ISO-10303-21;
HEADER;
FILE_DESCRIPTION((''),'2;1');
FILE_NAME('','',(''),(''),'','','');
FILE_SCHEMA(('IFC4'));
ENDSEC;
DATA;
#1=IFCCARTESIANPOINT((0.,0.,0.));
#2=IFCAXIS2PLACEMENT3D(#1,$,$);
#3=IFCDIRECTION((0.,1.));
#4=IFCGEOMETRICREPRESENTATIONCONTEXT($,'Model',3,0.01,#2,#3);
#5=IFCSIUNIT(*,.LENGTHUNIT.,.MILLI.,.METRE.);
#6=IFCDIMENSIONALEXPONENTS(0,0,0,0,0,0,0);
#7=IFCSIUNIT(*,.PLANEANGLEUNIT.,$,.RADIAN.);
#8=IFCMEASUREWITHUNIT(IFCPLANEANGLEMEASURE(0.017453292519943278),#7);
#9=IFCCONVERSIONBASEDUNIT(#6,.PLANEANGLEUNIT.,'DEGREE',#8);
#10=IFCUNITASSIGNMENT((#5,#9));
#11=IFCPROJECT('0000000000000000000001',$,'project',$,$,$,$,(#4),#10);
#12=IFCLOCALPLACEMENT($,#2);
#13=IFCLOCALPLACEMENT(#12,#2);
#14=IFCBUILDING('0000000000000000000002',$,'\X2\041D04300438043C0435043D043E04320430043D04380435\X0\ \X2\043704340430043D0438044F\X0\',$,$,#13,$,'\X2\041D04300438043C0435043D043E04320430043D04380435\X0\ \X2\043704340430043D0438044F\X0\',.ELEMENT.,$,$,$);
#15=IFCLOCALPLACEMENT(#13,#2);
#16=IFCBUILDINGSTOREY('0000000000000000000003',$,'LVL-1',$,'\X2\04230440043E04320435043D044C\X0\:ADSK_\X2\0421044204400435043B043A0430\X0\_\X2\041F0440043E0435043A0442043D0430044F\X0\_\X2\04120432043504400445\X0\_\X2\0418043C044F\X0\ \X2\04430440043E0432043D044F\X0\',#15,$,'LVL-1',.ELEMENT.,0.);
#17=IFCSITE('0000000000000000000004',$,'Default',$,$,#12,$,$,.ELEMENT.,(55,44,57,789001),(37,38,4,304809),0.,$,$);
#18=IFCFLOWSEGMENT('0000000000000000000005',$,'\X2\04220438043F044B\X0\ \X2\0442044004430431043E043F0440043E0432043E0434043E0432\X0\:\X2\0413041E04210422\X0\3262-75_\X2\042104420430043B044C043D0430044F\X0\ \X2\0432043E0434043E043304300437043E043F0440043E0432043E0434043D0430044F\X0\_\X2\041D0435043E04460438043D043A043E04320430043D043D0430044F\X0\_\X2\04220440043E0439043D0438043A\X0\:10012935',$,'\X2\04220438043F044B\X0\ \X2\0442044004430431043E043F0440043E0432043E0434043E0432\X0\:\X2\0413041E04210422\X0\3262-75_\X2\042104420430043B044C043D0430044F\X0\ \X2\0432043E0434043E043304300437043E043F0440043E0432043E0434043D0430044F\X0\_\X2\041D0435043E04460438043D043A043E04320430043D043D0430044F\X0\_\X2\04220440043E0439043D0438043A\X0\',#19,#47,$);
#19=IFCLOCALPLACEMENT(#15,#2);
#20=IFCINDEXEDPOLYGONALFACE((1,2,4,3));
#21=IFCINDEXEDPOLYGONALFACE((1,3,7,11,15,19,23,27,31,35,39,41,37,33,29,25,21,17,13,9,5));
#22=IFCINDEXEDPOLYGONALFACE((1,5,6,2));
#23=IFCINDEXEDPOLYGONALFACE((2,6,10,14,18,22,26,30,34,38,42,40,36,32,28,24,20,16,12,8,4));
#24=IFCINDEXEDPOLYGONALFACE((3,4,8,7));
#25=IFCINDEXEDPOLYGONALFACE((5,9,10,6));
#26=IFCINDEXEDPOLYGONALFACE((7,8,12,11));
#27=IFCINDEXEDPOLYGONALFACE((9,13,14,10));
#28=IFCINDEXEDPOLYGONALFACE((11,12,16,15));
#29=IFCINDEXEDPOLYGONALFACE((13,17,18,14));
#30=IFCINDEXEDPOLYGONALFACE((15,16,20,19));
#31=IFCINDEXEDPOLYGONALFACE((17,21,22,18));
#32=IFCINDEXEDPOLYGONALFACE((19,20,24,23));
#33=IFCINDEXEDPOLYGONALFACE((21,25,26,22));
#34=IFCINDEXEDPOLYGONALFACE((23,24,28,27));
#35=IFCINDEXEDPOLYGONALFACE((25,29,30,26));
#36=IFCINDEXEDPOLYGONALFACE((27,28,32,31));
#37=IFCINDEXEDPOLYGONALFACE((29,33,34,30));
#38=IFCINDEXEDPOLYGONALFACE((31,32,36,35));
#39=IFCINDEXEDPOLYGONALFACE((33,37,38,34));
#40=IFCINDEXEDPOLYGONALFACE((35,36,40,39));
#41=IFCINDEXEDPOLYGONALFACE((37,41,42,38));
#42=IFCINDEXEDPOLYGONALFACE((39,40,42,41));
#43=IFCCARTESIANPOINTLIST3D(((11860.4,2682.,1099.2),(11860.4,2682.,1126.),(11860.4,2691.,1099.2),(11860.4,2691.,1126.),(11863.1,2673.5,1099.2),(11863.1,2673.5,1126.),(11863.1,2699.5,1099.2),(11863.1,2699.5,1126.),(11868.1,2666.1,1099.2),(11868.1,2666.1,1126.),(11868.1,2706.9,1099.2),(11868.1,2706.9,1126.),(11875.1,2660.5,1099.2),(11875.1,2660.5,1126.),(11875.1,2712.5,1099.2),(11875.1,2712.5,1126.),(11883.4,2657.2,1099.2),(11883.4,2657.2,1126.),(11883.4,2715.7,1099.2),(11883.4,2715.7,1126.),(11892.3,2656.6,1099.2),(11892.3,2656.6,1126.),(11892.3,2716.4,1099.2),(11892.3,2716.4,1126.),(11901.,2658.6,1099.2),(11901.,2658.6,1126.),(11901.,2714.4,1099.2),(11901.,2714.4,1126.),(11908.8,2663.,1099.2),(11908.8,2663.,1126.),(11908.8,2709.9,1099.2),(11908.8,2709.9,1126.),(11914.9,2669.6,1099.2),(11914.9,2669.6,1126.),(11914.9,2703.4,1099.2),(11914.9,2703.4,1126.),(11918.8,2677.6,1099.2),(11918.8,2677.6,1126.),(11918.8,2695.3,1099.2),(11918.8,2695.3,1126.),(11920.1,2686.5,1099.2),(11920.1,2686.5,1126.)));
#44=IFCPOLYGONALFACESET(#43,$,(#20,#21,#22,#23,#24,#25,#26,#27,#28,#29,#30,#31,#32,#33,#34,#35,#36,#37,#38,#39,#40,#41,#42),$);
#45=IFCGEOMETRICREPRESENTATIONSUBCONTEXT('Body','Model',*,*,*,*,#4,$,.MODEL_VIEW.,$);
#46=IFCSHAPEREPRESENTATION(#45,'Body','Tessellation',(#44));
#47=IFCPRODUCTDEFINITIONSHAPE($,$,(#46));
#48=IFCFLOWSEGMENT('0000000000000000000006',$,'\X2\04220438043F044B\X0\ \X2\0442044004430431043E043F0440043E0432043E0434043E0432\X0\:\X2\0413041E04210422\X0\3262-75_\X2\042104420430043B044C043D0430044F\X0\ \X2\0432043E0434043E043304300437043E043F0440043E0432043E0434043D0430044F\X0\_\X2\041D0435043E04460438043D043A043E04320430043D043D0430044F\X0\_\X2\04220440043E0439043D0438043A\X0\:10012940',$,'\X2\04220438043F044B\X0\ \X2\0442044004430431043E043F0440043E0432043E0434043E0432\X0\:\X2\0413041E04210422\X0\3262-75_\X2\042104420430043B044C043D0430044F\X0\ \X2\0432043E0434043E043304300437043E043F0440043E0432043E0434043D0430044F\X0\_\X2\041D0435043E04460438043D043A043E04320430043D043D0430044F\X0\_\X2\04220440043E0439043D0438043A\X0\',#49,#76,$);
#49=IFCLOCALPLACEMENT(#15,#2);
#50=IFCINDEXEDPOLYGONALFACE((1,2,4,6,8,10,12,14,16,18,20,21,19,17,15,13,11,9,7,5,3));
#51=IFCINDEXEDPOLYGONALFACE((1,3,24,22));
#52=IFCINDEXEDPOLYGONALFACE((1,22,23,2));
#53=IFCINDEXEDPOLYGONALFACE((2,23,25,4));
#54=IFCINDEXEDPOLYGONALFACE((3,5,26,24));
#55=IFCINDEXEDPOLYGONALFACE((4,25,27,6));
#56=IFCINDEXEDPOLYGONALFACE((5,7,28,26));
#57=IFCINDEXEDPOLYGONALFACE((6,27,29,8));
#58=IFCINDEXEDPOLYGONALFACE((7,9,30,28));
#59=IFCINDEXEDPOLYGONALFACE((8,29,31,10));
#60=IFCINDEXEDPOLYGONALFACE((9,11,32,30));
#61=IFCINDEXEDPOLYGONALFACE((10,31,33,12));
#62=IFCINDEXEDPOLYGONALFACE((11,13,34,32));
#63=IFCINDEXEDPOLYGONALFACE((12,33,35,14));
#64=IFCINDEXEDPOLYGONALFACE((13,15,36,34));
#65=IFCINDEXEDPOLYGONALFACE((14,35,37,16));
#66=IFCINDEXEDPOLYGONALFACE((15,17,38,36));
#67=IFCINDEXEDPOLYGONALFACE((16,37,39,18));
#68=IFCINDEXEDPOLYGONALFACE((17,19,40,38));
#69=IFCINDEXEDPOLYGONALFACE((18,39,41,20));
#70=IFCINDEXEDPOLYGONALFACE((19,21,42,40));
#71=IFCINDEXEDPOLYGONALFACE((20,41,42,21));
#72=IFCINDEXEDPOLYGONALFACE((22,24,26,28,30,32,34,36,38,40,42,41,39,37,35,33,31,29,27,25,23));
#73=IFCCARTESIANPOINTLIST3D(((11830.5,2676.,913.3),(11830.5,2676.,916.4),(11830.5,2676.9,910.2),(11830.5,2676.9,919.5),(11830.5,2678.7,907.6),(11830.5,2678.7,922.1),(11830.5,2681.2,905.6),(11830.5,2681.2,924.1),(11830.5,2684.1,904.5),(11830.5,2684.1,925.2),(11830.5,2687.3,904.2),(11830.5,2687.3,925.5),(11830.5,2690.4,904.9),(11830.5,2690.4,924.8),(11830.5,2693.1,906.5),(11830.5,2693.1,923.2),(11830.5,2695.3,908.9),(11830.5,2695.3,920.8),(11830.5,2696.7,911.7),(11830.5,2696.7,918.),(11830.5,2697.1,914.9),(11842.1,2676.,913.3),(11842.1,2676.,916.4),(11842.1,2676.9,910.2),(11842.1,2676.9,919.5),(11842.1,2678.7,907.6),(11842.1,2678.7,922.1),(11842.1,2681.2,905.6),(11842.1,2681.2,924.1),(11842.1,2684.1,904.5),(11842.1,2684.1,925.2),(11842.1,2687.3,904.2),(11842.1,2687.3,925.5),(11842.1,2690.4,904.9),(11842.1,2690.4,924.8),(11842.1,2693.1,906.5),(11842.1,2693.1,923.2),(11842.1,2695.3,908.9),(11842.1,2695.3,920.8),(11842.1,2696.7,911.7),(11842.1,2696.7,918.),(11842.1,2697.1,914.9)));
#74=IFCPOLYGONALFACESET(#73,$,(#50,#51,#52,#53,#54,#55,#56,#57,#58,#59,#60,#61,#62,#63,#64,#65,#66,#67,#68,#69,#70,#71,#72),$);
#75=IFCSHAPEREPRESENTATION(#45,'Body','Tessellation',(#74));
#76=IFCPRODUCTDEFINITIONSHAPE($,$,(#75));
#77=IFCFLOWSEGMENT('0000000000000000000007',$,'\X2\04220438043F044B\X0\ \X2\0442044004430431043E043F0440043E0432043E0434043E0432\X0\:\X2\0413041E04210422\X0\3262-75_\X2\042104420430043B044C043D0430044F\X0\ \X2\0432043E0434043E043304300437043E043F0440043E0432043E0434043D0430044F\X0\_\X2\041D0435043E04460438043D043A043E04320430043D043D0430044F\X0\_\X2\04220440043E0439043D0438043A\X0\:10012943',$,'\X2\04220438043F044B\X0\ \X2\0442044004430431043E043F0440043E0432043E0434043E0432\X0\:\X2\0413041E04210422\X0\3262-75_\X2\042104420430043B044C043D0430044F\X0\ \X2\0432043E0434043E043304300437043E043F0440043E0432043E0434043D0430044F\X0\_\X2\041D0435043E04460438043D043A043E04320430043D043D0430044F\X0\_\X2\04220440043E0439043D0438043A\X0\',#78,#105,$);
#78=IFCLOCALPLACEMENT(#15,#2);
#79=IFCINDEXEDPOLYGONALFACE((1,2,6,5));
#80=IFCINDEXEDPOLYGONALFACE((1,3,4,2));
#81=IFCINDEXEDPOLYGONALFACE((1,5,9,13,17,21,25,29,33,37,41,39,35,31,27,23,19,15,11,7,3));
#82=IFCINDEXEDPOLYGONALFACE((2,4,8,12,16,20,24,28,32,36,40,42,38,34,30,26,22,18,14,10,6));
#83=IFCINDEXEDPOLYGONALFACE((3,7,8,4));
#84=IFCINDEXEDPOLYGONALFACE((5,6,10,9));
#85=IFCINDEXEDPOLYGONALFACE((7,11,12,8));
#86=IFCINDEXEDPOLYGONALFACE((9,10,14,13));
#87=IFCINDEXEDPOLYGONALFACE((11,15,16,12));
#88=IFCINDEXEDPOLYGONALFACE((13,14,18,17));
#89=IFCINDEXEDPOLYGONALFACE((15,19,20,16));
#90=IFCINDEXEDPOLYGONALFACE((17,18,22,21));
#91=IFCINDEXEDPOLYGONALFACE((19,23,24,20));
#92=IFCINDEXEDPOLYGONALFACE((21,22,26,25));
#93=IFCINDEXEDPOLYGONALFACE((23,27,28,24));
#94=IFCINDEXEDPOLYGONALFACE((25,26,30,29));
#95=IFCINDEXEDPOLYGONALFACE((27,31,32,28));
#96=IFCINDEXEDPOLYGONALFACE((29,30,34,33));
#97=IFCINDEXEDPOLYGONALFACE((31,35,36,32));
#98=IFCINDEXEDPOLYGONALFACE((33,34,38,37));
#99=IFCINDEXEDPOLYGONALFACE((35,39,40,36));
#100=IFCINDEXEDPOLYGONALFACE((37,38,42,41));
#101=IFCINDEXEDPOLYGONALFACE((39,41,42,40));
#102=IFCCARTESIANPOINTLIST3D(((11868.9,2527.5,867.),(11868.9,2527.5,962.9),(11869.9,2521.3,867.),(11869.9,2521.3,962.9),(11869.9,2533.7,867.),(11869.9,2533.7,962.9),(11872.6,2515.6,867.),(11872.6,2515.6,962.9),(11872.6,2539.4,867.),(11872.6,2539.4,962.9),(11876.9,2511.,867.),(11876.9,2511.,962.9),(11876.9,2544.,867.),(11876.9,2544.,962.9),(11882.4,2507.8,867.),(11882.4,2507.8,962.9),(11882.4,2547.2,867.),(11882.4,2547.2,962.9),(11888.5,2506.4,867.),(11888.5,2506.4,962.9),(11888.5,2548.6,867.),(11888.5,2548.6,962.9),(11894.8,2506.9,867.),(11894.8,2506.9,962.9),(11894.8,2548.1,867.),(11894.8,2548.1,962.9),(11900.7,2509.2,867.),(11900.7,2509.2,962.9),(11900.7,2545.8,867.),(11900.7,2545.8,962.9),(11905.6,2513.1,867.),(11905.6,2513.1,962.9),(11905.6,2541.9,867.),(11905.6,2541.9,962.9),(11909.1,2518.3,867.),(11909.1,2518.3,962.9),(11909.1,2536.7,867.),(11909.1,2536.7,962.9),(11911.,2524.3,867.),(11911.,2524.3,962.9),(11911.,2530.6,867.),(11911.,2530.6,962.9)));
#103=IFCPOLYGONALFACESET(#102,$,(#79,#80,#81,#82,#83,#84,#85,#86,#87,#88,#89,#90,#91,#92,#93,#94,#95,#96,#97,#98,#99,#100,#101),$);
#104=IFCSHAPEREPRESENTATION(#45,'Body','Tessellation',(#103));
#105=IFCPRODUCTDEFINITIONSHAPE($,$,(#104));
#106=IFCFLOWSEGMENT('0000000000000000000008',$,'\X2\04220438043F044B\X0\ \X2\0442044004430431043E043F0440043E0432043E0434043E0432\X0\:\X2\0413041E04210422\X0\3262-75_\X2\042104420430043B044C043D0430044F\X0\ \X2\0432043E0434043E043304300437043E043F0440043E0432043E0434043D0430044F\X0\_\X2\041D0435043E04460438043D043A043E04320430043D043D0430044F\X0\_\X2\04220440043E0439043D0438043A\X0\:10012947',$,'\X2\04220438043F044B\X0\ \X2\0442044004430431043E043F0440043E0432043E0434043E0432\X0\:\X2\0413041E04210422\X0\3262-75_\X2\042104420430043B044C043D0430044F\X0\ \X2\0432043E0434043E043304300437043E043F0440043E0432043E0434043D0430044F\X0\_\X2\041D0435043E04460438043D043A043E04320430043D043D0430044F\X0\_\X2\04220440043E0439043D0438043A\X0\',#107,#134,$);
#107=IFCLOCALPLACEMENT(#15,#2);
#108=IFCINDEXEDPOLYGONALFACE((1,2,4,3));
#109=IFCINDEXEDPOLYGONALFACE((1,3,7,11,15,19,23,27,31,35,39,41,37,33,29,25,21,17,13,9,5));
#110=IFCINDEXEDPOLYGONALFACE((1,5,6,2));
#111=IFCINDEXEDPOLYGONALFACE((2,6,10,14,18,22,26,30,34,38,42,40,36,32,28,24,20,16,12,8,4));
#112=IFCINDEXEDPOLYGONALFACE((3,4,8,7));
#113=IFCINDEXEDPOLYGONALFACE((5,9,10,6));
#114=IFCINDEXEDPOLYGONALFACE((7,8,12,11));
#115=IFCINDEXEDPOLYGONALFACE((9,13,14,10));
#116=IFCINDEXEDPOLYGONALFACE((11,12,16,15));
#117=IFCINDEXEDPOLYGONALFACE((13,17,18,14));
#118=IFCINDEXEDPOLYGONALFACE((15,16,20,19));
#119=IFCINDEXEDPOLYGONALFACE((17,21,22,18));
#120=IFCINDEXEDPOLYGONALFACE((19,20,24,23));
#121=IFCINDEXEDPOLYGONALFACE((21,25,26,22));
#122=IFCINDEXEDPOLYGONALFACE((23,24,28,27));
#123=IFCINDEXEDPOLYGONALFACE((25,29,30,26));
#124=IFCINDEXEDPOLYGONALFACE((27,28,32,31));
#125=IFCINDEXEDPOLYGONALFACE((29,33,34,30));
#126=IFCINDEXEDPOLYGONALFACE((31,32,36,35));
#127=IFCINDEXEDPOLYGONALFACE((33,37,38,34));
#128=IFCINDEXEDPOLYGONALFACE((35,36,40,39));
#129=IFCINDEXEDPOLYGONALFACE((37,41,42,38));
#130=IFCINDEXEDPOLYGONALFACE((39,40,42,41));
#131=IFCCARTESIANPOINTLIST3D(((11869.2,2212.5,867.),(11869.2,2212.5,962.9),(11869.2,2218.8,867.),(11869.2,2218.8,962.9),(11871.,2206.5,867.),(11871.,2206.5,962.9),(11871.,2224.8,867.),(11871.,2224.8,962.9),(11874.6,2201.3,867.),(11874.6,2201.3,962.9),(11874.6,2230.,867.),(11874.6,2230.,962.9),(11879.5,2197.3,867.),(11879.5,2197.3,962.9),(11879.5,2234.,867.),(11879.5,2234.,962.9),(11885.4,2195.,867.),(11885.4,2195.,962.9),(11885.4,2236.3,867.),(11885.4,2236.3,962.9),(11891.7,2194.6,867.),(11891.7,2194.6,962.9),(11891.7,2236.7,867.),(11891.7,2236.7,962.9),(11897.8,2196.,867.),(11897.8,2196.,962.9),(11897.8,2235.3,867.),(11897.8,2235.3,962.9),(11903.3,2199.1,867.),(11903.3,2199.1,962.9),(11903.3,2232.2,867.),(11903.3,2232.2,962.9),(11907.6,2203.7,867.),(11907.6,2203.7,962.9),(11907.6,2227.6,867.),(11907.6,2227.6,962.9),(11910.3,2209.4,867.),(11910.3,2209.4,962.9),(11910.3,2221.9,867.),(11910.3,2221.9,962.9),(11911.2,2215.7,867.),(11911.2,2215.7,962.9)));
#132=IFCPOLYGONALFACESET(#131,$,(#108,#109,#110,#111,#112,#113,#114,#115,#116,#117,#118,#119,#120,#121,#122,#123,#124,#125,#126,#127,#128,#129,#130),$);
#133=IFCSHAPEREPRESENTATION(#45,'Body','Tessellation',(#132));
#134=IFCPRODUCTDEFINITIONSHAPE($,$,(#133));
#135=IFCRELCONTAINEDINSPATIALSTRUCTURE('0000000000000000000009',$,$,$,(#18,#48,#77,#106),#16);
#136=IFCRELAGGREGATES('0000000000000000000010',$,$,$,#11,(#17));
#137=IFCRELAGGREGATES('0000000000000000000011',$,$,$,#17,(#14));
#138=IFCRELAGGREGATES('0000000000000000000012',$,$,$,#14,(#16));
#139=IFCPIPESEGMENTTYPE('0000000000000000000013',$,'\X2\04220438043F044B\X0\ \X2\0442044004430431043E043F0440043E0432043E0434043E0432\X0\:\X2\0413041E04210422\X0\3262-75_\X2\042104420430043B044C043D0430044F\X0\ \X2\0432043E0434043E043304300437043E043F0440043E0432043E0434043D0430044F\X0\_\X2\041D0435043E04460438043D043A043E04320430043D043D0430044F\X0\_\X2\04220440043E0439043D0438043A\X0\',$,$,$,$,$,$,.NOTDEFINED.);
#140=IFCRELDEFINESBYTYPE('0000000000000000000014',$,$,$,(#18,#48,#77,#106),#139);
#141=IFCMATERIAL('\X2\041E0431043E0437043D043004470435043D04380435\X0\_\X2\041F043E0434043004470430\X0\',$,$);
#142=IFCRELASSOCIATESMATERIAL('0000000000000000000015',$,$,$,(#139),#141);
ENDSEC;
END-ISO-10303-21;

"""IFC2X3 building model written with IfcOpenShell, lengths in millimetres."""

from ifc_helpers import new_model, entity, si_unit, converted_unit, direction, frame, origin, origin_2d_with_axis, place, context, subcontext, project, spatial, circle, extrude, material, type_object, element, save


model = new_model("IFC2X3")

# Units and contexts
model_context = context("Model", 3, precision=0.01, world=origin(), true_north=direction((0.0, 1.0)))
body_context = subcontext(model_context, "Body", "Model", "MODEL_VIEW")
ifc_project = project(units=[si_unit("LENGTHUNIT", "METRE", prefix="MILLI"), converted_unit("PLANEANGLEUNIT", "DEGREE", entity("IfcPlaneAngleMeasure", 0.017453292519943278), si_unit("PLANEANGLEUNIT", "RADIAN"), dimensions=[0, 0, 0, 0, 0, 0, 0])], contexts=[model_context])

# Site, building, storey
site_placement = place(None, origin())
site = spatial("IfcSite", under=ifc_project, at=site_placement, Name="Default", CompositionType="ELEMENT", RefLatitude=(55, 44, 57, 789001), RefLongitude=(37, 38, 4, 304809), RefElevation=0.0)
building_placement = place(site_placement, origin())
building = spatial("IfcBuilding", under=site, at=building_placement, Name="Наименование здания", LongName="Наименование здания", CompositionType="ELEMENT")
storey_placement = place(building_placement, origin())
storey = spatial("IfcBuildingStorey", under=building, at=storey_placement, Name="LVL-1", ObjectType="Уровень:ADSK_Стрелка_Проектная_Вверх_Имя уровня", LongName="LVL-1", CompositionType="ELEMENT", Elevation=0.0)

# Flow segments
ifc_material_1 = material(Name="Обозначение_Подача")
pipe_segment_type_1 = type_object("IfcPipeSegmentType", Name="Типы трубопроводов:ГОСТ3262-75_Стальная водогазопроводная_Неоцинкованная_Тройник", PredefinedType="NOTDEFINED", material=ifc_material_1)
flow_segment_1_placement = place(storey_placement, origin())
element("IfcFlowSegment", 1, at=flow_segment_1_placement, inside=storey, type_object=pipe_segment_type_1, Name="Типы трубопроводов:ГОСТ3262-75_Стальная водогазопроводная_Неоцинкованная_Тройник:10012935", ObjectType="Типы трубопроводов:ГОСТ3262-75_Стальная водогазопроводная_Неоцинкованная_Тройник", context=body_context, shape_type="SweptSolid", body=[
    extrude(circle(Radius=30.0, at=origin_2d_with_axis()), frame((11890.1, 2686.5, 1099.2)), (0.0, 0.0, 1.0), 26.8),
])
flow_segment_2_placement = place(storey_placement, origin())
element("IfcFlowSegment", 2, at=flow_segment_2_placement, inside=storey, type_object=pipe_segment_type_1, Name="Типы трубопроводов:ГОСТ3262-75_Стальная водогазопроводная_Неоцинкованная_Тройник:10012940", ObjectType="Типы трубопроводов:ГОСТ3262-75_Стальная водогазопроводная_Неоцинкованная_Тройник", context=body_context, shape_type="SweptSolid", body=[
    extrude(circle(Radius=10.7, at=origin_2d_with_axis()), frame((11830.5, 2686.5, 914.9), z_axis=(1.0, 0.0, 0.0), x_axis=(0.0, 1.0, 0.0)), (0.0, 0.0, 1.0), 11.6),
])
flow_segment_3_placement = place(storey_placement, origin())
element("IfcFlowSegment", 3, at=flow_segment_3_placement, inside=storey, type_object=pipe_segment_type_1, Name="Типы трубопроводов:ГОСТ3262-75_Стальная водогазопроводная_Неоцинкованная_Тройник:10012943", ObjectType="Типы трубопроводов:ГОСТ3262-75_Стальная водогазопроводная_Неоцинкованная_Тройник", context=body_context, shape_type="SweptSolid", body=[
    extrude(circle(Radius=21.1, at=origin_2d_with_axis()), frame((11890.1, 2527.5, 867.0), z_axis=(0.0, 0.0, 1.0), x_axis=(-1.0, 0.0, 0.0)), (0.0, 0.0, 1.0), 95.9),
])
flow_segment_4_placement = place(storey_placement, origin())
element("IfcFlowSegment", 4, at=flow_segment_4_placement, inside=storey, type_object=pipe_segment_type_1, Name="Типы трубопроводов:ГОСТ3262-75_Стальная водогазопроводная_Неоцинкованная_Тройник:10012947", ObjectType="Типы трубопроводов:ГОСТ3262-75_Стальная водогазопроводная_Неоцинкованная_Тройник", context=body_context, shape_type="SweptSolid", body=[
    extrude(circle(Radius=21.1, at=origin_2d_with_axis()), frame((11890.1, 2215.7, 867.0)), (0.0, 0.0, 1.0), 95.9),
])

save(model, "model.ifc")
